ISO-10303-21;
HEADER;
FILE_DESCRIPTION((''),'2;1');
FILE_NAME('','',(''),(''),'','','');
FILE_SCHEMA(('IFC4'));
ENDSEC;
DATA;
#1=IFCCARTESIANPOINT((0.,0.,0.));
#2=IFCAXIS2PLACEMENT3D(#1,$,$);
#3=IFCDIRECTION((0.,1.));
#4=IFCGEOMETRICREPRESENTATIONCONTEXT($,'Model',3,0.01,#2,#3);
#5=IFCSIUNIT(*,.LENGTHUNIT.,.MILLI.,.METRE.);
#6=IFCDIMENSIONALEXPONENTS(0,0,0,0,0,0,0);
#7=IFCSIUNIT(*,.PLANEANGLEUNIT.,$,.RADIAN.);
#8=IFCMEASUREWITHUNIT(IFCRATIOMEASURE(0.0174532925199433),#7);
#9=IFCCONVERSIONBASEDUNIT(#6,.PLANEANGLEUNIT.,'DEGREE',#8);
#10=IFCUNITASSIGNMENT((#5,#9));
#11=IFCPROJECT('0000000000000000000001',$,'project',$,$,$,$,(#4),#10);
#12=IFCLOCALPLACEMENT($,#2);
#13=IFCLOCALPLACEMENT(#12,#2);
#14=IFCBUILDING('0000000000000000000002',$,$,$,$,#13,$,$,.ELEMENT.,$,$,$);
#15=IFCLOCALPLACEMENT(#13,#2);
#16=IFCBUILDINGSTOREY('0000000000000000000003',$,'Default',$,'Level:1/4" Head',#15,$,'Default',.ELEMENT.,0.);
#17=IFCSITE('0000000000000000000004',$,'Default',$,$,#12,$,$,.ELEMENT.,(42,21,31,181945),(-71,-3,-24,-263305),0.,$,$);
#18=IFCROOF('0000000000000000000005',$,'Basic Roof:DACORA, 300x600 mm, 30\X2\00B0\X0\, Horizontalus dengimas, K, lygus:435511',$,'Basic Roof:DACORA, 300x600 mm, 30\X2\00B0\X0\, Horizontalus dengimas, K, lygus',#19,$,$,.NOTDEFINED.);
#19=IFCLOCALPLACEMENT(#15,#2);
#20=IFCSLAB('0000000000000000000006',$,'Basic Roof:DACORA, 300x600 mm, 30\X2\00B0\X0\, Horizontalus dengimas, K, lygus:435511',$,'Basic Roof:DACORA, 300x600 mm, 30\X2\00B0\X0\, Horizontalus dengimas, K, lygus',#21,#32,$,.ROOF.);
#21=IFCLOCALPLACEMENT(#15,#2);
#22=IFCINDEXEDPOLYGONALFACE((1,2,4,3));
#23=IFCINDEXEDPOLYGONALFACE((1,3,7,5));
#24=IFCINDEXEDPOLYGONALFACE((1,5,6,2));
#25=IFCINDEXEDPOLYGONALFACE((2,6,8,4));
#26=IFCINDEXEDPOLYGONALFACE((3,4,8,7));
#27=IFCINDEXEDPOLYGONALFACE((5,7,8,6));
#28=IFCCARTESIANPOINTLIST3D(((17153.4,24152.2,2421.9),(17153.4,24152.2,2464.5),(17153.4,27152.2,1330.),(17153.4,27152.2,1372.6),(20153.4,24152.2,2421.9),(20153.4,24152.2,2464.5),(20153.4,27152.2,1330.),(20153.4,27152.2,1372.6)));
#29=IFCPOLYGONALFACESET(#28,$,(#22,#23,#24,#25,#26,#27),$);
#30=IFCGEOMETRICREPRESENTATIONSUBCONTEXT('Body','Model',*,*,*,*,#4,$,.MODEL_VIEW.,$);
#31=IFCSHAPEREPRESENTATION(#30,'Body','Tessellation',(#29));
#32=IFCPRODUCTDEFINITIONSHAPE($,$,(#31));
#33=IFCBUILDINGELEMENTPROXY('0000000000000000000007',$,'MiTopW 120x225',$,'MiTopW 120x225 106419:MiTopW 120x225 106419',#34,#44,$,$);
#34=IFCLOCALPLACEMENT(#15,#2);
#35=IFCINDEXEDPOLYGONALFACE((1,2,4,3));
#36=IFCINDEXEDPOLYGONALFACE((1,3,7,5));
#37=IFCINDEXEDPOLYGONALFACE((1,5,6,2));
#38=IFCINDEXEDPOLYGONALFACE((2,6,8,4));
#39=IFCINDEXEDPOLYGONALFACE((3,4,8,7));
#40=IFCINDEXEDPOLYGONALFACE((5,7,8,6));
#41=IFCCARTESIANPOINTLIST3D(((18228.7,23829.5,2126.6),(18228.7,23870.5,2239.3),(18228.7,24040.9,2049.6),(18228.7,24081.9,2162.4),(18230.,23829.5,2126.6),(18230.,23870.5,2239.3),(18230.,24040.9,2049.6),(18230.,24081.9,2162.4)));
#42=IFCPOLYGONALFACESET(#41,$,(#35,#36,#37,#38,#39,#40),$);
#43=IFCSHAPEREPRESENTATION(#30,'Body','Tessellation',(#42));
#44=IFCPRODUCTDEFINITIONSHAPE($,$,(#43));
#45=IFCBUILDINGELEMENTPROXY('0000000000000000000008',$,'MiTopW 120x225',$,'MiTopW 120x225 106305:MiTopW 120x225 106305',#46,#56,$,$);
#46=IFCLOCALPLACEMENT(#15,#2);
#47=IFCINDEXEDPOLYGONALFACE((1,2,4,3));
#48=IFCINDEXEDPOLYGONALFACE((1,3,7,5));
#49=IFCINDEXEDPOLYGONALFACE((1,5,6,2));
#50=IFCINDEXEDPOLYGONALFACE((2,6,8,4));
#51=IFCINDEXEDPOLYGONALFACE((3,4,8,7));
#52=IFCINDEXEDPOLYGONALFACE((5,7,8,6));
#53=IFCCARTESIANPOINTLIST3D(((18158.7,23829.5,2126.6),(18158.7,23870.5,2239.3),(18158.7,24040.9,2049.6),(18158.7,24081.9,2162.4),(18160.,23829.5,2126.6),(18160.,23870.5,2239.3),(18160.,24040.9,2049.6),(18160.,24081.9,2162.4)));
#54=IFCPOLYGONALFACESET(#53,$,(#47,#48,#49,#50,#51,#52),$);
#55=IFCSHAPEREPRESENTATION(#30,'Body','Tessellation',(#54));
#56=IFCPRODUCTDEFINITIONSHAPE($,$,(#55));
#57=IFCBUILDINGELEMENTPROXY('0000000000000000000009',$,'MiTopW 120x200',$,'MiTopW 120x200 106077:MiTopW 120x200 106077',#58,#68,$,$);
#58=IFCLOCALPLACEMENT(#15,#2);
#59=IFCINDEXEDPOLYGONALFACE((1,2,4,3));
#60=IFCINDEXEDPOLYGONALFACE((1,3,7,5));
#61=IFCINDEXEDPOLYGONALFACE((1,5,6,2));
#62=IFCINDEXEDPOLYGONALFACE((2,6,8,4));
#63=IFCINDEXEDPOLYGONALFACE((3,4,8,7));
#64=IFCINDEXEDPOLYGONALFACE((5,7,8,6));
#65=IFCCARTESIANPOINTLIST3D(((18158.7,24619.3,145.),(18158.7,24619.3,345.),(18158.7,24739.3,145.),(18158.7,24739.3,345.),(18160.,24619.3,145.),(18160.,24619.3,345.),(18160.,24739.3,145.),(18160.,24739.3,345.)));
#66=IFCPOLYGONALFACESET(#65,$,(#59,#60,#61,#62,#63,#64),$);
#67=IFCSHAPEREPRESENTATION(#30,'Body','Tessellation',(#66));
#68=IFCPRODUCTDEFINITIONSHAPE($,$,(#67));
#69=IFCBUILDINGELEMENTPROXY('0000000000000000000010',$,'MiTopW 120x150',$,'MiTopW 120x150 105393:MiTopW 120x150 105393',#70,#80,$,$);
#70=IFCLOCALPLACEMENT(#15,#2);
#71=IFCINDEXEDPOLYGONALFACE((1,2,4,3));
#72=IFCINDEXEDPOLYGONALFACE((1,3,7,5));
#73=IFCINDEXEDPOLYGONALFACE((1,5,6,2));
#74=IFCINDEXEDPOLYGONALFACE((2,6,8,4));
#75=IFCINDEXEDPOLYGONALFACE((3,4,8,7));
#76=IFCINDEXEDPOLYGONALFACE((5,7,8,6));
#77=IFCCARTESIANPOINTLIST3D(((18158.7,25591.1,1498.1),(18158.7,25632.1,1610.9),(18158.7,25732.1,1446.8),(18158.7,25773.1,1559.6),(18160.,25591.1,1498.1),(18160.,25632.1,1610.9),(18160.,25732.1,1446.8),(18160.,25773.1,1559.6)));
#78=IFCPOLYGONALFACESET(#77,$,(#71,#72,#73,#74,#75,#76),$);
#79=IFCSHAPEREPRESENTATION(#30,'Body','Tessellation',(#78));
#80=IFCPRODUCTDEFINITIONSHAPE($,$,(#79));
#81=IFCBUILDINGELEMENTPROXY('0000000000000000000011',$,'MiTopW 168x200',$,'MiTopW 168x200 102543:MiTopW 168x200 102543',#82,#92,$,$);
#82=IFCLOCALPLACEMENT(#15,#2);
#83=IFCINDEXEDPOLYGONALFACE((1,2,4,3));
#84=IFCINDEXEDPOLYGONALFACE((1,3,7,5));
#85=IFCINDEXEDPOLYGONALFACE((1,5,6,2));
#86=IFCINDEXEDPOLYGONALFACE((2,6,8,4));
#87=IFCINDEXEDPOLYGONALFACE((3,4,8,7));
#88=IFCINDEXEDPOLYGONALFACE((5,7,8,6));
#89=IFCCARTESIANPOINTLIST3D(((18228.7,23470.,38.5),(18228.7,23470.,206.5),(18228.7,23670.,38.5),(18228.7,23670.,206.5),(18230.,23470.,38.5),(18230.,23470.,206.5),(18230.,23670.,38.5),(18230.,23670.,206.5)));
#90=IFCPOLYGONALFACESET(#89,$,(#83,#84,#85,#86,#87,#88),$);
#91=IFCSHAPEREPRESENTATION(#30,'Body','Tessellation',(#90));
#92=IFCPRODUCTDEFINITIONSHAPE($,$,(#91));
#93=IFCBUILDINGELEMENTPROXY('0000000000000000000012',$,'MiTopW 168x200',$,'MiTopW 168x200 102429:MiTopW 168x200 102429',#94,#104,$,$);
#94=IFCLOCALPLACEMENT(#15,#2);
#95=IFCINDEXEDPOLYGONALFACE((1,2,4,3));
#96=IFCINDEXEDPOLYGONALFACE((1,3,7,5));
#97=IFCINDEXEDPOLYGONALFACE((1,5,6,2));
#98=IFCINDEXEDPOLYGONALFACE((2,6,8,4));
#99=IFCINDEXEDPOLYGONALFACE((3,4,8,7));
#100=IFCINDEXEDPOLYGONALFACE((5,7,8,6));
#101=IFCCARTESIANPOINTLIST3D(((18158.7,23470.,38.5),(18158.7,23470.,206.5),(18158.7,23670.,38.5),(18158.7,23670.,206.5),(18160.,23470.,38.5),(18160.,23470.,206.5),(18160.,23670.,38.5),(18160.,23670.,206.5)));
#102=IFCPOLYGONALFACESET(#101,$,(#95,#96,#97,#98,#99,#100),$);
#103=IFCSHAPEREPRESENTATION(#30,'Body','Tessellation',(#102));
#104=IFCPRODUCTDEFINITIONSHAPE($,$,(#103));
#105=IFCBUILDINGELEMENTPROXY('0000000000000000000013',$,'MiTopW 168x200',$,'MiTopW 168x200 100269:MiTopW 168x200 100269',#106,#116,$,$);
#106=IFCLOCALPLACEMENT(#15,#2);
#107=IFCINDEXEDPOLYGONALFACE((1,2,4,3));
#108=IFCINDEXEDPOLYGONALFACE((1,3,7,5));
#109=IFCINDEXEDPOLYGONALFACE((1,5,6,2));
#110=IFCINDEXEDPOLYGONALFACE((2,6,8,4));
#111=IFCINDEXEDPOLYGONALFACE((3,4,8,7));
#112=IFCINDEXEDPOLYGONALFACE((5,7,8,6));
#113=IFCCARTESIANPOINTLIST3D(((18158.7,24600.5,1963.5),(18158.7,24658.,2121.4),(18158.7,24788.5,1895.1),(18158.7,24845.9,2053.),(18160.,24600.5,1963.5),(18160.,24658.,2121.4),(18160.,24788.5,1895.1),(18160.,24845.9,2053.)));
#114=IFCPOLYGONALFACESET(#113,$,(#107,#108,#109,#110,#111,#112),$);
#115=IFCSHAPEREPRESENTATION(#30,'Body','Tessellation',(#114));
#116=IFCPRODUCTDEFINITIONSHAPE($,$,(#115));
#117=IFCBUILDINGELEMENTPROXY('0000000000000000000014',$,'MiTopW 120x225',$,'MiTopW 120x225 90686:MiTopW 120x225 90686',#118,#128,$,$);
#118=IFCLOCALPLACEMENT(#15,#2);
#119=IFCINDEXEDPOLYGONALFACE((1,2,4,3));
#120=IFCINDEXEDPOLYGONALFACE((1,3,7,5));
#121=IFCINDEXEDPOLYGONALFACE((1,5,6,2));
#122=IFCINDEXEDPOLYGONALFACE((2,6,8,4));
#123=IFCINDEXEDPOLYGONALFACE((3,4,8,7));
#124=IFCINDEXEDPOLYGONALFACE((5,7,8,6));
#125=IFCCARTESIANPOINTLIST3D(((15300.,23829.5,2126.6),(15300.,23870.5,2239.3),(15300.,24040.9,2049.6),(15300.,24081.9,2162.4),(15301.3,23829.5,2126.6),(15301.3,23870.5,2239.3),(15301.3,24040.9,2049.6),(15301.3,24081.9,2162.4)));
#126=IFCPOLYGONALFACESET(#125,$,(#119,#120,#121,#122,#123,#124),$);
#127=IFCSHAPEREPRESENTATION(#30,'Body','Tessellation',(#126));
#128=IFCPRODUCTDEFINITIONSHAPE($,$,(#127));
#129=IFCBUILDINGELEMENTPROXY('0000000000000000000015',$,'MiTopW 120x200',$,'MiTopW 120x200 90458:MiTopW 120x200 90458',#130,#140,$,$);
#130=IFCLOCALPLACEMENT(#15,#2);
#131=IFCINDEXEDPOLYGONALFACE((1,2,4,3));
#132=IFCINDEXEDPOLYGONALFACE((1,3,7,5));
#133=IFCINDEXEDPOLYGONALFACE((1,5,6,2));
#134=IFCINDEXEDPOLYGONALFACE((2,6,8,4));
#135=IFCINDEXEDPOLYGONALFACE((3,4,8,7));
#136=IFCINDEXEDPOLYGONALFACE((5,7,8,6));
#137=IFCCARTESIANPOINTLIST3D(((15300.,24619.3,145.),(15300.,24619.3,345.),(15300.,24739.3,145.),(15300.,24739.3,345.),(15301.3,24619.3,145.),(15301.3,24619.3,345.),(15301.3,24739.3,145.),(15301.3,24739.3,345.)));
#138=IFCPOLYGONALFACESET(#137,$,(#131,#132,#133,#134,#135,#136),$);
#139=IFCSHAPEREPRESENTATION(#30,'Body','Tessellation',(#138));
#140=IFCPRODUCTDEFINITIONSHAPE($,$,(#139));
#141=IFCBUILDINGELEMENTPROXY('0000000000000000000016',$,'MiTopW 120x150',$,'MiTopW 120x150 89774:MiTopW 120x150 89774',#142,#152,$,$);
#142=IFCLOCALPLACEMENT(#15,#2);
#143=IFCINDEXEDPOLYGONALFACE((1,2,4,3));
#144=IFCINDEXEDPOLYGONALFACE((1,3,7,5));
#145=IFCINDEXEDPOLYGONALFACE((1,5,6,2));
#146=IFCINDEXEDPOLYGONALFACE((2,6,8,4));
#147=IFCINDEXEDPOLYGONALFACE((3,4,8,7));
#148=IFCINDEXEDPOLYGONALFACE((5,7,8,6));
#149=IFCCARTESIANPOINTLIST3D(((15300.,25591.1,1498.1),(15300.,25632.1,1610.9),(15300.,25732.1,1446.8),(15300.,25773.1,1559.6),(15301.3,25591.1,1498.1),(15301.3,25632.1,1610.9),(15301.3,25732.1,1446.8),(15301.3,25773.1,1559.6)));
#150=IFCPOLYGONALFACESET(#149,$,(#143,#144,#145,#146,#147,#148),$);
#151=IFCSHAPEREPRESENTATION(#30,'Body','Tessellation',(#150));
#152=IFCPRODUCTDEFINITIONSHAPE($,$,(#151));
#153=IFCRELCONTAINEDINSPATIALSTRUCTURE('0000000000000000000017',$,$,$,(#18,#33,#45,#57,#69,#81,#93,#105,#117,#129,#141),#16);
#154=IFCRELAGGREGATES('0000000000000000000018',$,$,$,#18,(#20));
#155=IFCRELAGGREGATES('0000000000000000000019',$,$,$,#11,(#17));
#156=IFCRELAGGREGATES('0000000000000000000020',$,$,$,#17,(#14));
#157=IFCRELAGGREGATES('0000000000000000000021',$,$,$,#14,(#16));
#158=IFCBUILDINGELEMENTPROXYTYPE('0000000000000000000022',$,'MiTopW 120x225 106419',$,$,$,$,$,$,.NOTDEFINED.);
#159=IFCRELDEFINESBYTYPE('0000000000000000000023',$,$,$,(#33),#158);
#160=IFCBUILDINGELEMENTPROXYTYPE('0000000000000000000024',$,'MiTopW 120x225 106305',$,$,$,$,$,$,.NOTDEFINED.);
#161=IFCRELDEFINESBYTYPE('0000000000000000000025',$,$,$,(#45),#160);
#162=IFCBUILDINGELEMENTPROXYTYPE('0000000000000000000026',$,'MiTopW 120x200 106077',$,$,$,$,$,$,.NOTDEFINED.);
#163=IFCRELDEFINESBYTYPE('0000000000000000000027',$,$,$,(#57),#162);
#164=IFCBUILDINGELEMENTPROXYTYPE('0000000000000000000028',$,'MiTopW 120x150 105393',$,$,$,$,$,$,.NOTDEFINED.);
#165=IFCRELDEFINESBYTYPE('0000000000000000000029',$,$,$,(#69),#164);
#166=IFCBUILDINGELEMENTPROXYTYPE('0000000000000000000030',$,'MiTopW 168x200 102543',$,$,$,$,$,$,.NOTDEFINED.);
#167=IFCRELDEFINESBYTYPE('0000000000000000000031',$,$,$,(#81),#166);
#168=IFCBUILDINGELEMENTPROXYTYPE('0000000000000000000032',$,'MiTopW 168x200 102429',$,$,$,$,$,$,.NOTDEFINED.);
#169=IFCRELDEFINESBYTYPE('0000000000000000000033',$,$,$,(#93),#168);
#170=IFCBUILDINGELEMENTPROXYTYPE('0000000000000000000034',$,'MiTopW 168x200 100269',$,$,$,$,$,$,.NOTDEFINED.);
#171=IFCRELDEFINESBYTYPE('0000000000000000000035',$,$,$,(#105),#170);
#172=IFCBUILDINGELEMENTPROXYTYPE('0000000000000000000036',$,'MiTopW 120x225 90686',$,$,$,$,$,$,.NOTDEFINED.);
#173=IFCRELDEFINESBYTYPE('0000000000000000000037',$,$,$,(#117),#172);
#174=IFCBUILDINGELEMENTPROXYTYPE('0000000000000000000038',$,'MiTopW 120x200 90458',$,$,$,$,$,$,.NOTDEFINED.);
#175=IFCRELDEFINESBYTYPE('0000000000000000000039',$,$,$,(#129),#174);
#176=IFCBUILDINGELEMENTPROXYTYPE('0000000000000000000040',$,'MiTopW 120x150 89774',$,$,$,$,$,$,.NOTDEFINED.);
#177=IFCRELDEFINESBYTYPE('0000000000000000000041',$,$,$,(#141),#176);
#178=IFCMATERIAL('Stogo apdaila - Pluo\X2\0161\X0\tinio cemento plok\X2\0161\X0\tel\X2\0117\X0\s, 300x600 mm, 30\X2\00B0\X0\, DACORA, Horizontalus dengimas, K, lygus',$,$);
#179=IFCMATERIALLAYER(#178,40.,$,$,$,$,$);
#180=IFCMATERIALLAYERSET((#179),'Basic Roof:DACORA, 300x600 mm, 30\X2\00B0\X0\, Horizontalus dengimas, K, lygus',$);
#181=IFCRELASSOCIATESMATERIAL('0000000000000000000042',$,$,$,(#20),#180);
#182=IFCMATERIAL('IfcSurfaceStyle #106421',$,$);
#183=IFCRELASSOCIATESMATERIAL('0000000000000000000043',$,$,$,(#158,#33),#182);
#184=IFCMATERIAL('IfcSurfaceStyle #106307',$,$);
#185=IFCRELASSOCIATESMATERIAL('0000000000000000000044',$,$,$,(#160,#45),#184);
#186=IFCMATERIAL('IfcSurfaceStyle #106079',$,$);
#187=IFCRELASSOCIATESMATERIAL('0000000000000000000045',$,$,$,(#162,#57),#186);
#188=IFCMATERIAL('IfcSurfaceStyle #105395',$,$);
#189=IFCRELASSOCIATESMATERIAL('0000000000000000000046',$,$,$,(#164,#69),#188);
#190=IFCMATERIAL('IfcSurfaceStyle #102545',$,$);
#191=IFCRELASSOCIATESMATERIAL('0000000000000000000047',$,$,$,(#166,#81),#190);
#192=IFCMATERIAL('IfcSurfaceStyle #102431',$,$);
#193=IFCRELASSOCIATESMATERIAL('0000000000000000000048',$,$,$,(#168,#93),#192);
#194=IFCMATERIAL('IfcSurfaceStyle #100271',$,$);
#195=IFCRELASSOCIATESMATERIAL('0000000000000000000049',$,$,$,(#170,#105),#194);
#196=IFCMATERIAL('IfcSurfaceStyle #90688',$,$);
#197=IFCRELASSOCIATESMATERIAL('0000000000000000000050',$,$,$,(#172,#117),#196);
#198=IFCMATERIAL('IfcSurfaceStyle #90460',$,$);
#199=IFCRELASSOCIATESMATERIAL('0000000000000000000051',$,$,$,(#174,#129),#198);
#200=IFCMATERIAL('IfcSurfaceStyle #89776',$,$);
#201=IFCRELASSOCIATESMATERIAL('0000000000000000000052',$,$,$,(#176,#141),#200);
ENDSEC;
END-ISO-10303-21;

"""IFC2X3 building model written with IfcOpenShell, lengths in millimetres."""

from ifc_helpers import new_model, entity, si_unit, converted_unit, direction, frame, frame_2d, origin, origin_2d_with_axis, place, context, subcontext, project, spatial, polyline, rectangle, outline, extrude, source, transform, mapped, material, layer, layer_set, type_object, type_shapes, element, aggregate, save


model = new_model("IFC2X3")

# Units and contexts
model_context = context("Model", 3, precision=0.01, world=origin(), true_north=direction((0.0, 1.0)))
body_context = subcontext(model_context, "Body", "Model", "MODEL_VIEW")
ifc_project = project(units=[si_unit("LENGTHUNIT", "METRE", prefix="MILLI"), converted_unit("PLANEANGLEUNIT", "DEGREE", entity("IfcRatioMeasure", 0.0174532925199433), si_unit("PLANEANGLEUNIT", "RADIAN"), dimensions=[0, 0, 0, 0, 0, 0, 0])], contexts=[model_context])

# Site, building, storey
site_placement = place(None, origin())
site = spatial("IfcSite", under=ifc_project, at=site_placement, Name="Default", CompositionType="ELEMENT", RefLatitude=(42, 21, 31, 181945), RefLongitude=(-71, -3, -24, -263305), RefElevation=0.0)
building_placement = place(site_placement, origin())
building = spatial("IfcBuilding", under=site, at=building_placement, CompositionType="ELEMENT")
storey_placement = place(building_placement, origin())
storey = spatial("IfcBuildingStorey", under=building, at=storey_placement, Name="Default", ObjectType="Level:1/4\" Head", LongName="Default", CompositionType="ELEMENT", Elevation=0.0)

# Roof, slab
roof_placement = place(storey_placement, frame((17153.4, 24152.2, 1330.0)))
roof = element("IfcRoof", 1, at=roof_placement, inside=storey, Name="Basic Roof:DACORA, 300x600 mm, 30°, Horizontalus dengimas, K, lygus:435511", ObjectType="Basic Roof:DACORA, 300x600 mm, 30°, Horizontalus dengimas, K, lygus", ShapeType="NOTDEFINED")
ifc_material_1 = material(Name="Stogo apdaila - Pluoštinio cemento plokštelės, 300x600 mm, 30°, DACORA, Horizontalus dengimas, K, lygus")
ifc_layer = layer(ifc_material_1, 40.0)
ifc_layer_set = layer_set([ifc_layer], Name="Basic Roof:DACORA, 300x600 mm, 30°, Horizontalus dengimas, K, lygus")
slab_placement = place(roof_placement, origin())
slab = element("IfcSlab", 2, at=slab_placement, material=ifc_layer_set, Name="Basic Roof:DACORA, 300x600 mm, 30°, Horizontalus dengimas, K, lygus:435511", ObjectType="Basic Roof:DACORA, 300x600 mm, 30°, Horizontalus dengimas, K, lygus", PredefinedType="ROOF", context=body_context, shape_type="SweptSolid", body=[
    extrude(rectangle(XDim=3192.5, YDim=3000.0, at=frame_2d((0.0, 0.0), x_axis=(0.0, 1.0))), frame((1500.0, 1500.0, 546.0), z_axis=(0.0, 0.34202, 0.939693), x_axis=(1.0, 0.0, 0.0)), (0.0, -0.34202, 0.939693), 42.6),
])
aggregate(roof, [slab])

# Building element proxies
ifc_material_2 = material(Name="IfcSurfaceStyle #106421")
building_element_proxy_type_1 = type_object("IfcBuildingElementProxyType", Name="MiTopW 120x225 106419", PredefinedType="NOTDEFINED", material=ifc_material_2)
shared_shape_1 = source(origin(), body_context, "Body", "SweptSolid", [
    extrude(outline(polyline([(-112.5, -60.0), (112.5, -60.0), (112.5, 60.0), (-112.5, 60.0), (-112.5, -60.0)])), frame((112.5, 60.0, 0.0), z_axis=(0.0, 0.0, 1.0), x_axis=(-1.0, 0.0, 0.0)), (0.0, 0.0, 1.0), 1.3),
])
type_shapes(building_element_proxy_type_1, [shared_shape_1])
proxy_1_placement = place(building_placement, frame((18230.0, 24040.9, 2049.6), z_axis=(-1.0, 0.0, 0.0), x_axis=(0.0, -0.939693, 0.34202)))
element("IfcBuildingElementProxy", 3, at=proxy_1_placement, inside=storey, type_object=building_element_proxy_type_1, material=ifc_material_2, Name="MiTopW 120x225", ObjectType="MiTopW 120x225 106419:MiTopW 120x225 106419", context=body_context, shape_type="MappedRepresentation", body=[
    mapped(shared_shape_1, transform((0.0, 0.0, 0.0), scale=1.0)),
])
ifc_material_3 = material(Name="IfcSurfaceStyle #106307")
building_element_proxy_type_2 = type_object("IfcBuildingElementProxyType", Name="MiTopW 120x225 106305", PredefinedType="NOTDEFINED", material=ifc_material_3)
shared_shape_2 = source(origin(), body_context, "Body", "SweptSolid", [
    extrude(outline(polyline([(-112.5, -60.0), (112.5, -60.0), (112.5, 60.0), (-112.5, 60.0), (-112.5, -60.0)])), frame((112.5, 60.0, 0.0), z_axis=(0.0, 0.0, 1.0), x_axis=(-1.0, 0.0, 0.0)), (0.0, 0.0, 1.0), 1.3),
])
type_shapes(building_element_proxy_type_2, [shared_shape_2])
proxy_2_placement = place(building_placement, frame((18160.0, 24040.9, 2049.6), z_axis=(-1.0, 0.0, 0.0), x_axis=(0.0, -0.939693, 0.34202)))
element("IfcBuildingElementProxy", 4, at=proxy_2_placement, inside=storey, type_object=building_element_proxy_type_2, material=ifc_material_3, Name="MiTopW 120x225", ObjectType="MiTopW 120x225 106305:MiTopW 120x225 106305", context=body_context, shape_type="MappedRepresentation", body=[
    mapped(shared_shape_2, transform((0.0, 0.0, 0.0), scale=1.0)),
])
ifc_material_4 = material(Name="IfcSurfaceStyle #106079")
building_element_proxy_type_3 = type_object("IfcBuildingElementProxyType", Name="MiTopW 120x200 106077", PredefinedType="NOTDEFINED", material=ifc_material_4)
shared_shape_3 = source(origin(), body_context, "Body", "SweptSolid", [
    extrude(rectangle(XDim=200.0, YDim=120.0, at=origin_2d_with_axis()), frame((100.0, 60.0, 0.0), z_axis=(0.0, 0.0, 1.0), x_axis=(-1.0, 0.0, 0.0)), (0.0, 0.0, 1.0), 1.3),
])
type_shapes(building_element_proxy_type_3, [shared_shape_3])
proxy_3_placement = place(building_placement, frame((18160.0, 24619.3, 145.0), z_axis=(-1.0, 0.0, 0.0), x_axis=(0.0, 0.0, 1.0)))
element("IfcBuildingElementProxy", 5, at=proxy_3_placement, inside=storey, type_object=building_element_proxy_type_3, material=ifc_material_4, Name="MiTopW 120x200", ObjectType="MiTopW 120x200 106077:MiTopW 120x200 106077", context=body_context, shape_type="MappedRepresentation", body=[
    mapped(shared_shape_3, transform((0.0, 0.0, 0.0), scale=1.0)),
])
ifc_material_5 = material(Name="IfcSurfaceStyle #105395")
building_element_proxy_type_4 = type_object("IfcBuildingElementProxyType", Name="MiTopW 120x150 105393", PredefinedType="NOTDEFINED", material=ifc_material_5)
shared_shape_4 = source(origin(), body_context, "Body", "SweptSolid", [
    extrude(outline(polyline([(-75.0, -60.0), (75.0, -60.0), (75.0, 60.0), (-75.0, 60.0), (-75.0, -60.0)])), frame((75.0, 60.0, 0.0), z_axis=(0.0, 0.0, 1.0), x_axis=(-1.0, 0.0, 0.0)), (0.0, 0.0, 1.0), 1.3),
])
type_shapes(building_element_proxy_type_4, [shared_shape_4])
proxy_4_placement = place(building_placement, frame((18160.0, 25732.1, 1446.8), z_axis=(-1.0, 0.0, 0.0), x_axis=(0.0, -0.939693, 0.34202)))
element("IfcBuildingElementProxy", 6, at=proxy_4_placement, inside=storey, type_object=building_element_proxy_type_4, material=ifc_material_5, Name="MiTopW 120x150", ObjectType="MiTopW 120x150 105393:MiTopW 120x150 105393", context=body_context, shape_type="MappedRepresentation", body=[
    mapped(shared_shape_4, transform((0.0, 0.0, 0.0), scale=1.0)),
])
ifc_material_6 = material(Name="IfcSurfaceStyle #102545")
building_element_proxy_type_5 = type_object("IfcBuildingElementProxyType", Name="MiTopW 168x200 102543", PredefinedType="NOTDEFINED", material=ifc_material_6)
shared_shape_5 = source(origin(), body_context, "Body", "SweptSolid", [
    extrude(rectangle(XDim=200.0, YDim=168.0, at=origin_2d_with_axis()), frame((100.0, 84.0, 0.0), z_axis=(0.0, 0.0, 1.0), x_axis=(-1.0, 0.0, 0.0)), (0.0, 0.0, 1.0), 1.3),
])
type_shapes(building_element_proxy_type_5, [shared_shape_5])
proxy_5_placement = place(building_placement, frame((18230.0, 23470.0, 206.5), z_axis=(-1.0, 0.0, 0.0), x_axis=(0.0, 1.0, 0.0)))
element("IfcBuildingElementProxy", 7, at=proxy_5_placement, inside=storey, type_object=building_element_proxy_type_5, material=ifc_material_6, Name="MiTopW 168x200", ObjectType="MiTopW 168x200 102543:MiTopW 168x200 102543", context=body_context, shape_type="MappedRepresentation", body=[
    mapped(shared_shape_5, transform((0.0, 0.0, 0.0), scale=1.0)),
])
ifc_material_7 = material(Name="IfcSurfaceStyle #102431")
building_element_proxy_type_6 = type_object("IfcBuildingElementProxyType", Name="MiTopW 168x200 102429", PredefinedType="NOTDEFINED", material=ifc_material_7)
shared_shape_6 = source(origin(), body_context, "Body", "SweptSolid", [
    extrude(rectangle(XDim=200.0, YDim=168.0, at=origin_2d_with_axis()), frame((100.0, 84.0, 0.0), z_axis=(0.0, 0.0, 1.0), x_axis=(-1.0, 0.0, 0.0)), (0.0, 0.0, 1.0), 1.3),
])
type_shapes(building_element_proxy_type_6, [shared_shape_6])
proxy_6_placement = place(building_placement, frame((18160.0, 23470.0, 206.5), z_axis=(-1.0, 0.0, 0.0), x_axis=(0.0, 1.0, 0.0)))
element("IfcBuildingElementProxy", 8, at=proxy_6_placement, inside=storey, type_object=building_element_proxy_type_6, material=ifc_material_7, Name="MiTopW 168x200", ObjectType="MiTopW 168x200 102429:MiTopW 168x200 102429", context=body_context, shape_type="MappedRepresentation", body=[
    mapped(shared_shape_6, transform((0.0, 0.0, 0.0), scale=1.0)),
])
ifc_material_8 = material(Name="IfcSurfaceStyle #100271")
building_element_proxy_type_7 = type_object("IfcBuildingElementProxyType", Name="MiTopW 168x200 100269", PredefinedType="NOTDEFINED", material=ifc_material_8)
shared_shape_7 = source(origin(), body_context, "Body", "SweptSolid", [
    extrude(outline(polyline([(-100.0, -84.0), (100.0, -84.0), (100.0, 84.0), (-100.0, 84.0), (-100.0, -84.0)])), frame((100.0, 84.0, 0.0), z_axis=(0.0, 0.0, 1.0), x_axis=(-1.0, 0.0, 0.0)), (0.0, 0.0, 1.0), 1.3),
])
type_shapes(building_element_proxy_type_7, [shared_shape_7])
proxy_7_placement = place(building_placement, frame((18160.0, 24788.5, 1895.1), z_axis=(-1.0, 0.0, 0.0), x_axis=(0.0, -0.939693, 0.34202)))
element("IfcBuildingElementProxy", 9, at=proxy_7_placement, inside=storey, type_object=building_element_proxy_type_7, material=ifc_material_8, Name="MiTopW 168x200", ObjectType="MiTopW 168x200 100269:MiTopW 168x200 100269", context=body_context, shape_type="MappedRepresentation", body=[
    mapped(shared_shape_7, transform((0.0, 0.0, 0.0), scale=1.0)),
])
ifc_material_9 = material(Name="IfcSurfaceStyle #90688")
building_element_proxy_type_8 = type_object("IfcBuildingElementProxyType", Name="MiTopW 120x225 90686", PredefinedType="NOTDEFINED", material=ifc_material_9)
shared_shape_8 = source(origin(), body_context, "Body", "SweptSolid", [
    extrude(outline(polyline([(-112.5, -60.0), (112.5, -60.0), (112.5, 60.0), (-112.5, 60.0), (-112.5, -60.0)])), frame((112.5, 60.0, 0.0), z_axis=(0.0, 0.0, 1.0), x_axis=(-1.0, 0.0, 0.0)), (0.0, 0.0, 1.0), 1.3),
])
type_shapes(building_element_proxy_type_8, [shared_shape_8])
proxy_8_placement = place(building_placement, frame((15301.3, 24040.9, 2049.6), z_axis=(-1.0, 0.0, 0.0), x_axis=(0.0, -0.939693, 0.34202)))
element("IfcBuildingElementProxy", 10, at=proxy_8_placement, inside=storey, type_object=building_element_proxy_type_8, material=ifc_material_9, Name="MiTopW 120x225", ObjectType="MiTopW 120x225 90686:MiTopW 120x225 90686", context=body_context, shape_type="MappedRepresentation", body=[
    mapped(shared_shape_8, transform((0.0, 0.0, 0.0), scale=1.0)),
])
ifc_material_10 = material(Name="IfcSurfaceStyle #90460")
building_element_proxy_type_9 = type_object("IfcBuildingElementProxyType", Name="MiTopW 120x200 90458", PredefinedType="NOTDEFINED", material=ifc_material_10)
shared_shape_9 = source(origin(), body_context, "Body", "SweptSolid", [
    extrude(rectangle(XDim=200.0, YDim=120.0, at=origin_2d_with_axis()), frame((100.0, 60.0, 0.0), z_axis=(0.0, 0.0, 1.0), x_axis=(-1.0, 0.0, 0.0)), (0.0, 0.0, 1.0), 1.3),
])
type_shapes(building_element_proxy_type_9, [shared_shape_9])
proxy_9_placement = place(building_placement, frame((15301.3, 24619.3, 145.0), z_axis=(-1.0, 0.0, 0.0), x_axis=(0.0, 0.0, 1.0)))
element("IfcBuildingElementProxy", 11, at=proxy_9_placement, inside=storey, type_object=building_element_proxy_type_9, material=ifc_material_10, Name="MiTopW 120x200", ObjectType="MiTopW 120x200 90458:MiTopW 120x200 90458", context=body_context, shape_type="MappedRepresentation", body=[
    mapped(shared_shape_9, transform((0.0, 0.0, 0.0), scale=1.0)),
])
ifc_material_11 = material(Name="IfcSurfaceStyle #89776")
building_element_proxy_type_10 = type_object("IfcBuildingElementProxyType", Name="MiTopW 120x150 89774", PredefinedType="NOTDEFINED", material=ifc_material_11)
shared_shape_10 = source(origin(), body_context, "Body", "SweptSolid", [
    extrude(outline(polyline([(-75.0, -60.0), (75.0, -60.0), (75.0, 60.0), (-75.0, 60.0), (-75.0, -60.0)])), frame((75.0, 60.0, 0.0), z_axis=(0.0, 0.0, 1.0), x_axis=(-1.0, 0.0, 0.0)), (0.0, 0.0, 1.0), 1.3),
])
type_shapes(building_element_proxy_type_10, [shared_shape_10])
proxy_10_placement = place(building_placement, frame((15301.3, 25732.1, 1446.8), z_axis=(-1.0, 0.0, 0.0), x_axis=(0.0, -0.939693, 0.34202)))
element("IfcBuildingElementProxy", 12, at=proxy_10_placement, inside=storey, type_object=building_element_proxy_type_10, material=ifc_material_11, Name="MiTopW 120x150", ObjectType="MiTopW 120x150 89774:MiTopW 120x150 89774", context=body_context, shape_type="MappedRepresentation", body=[
    mapped(shared_shape_10, transform((0.0, 0.0, 0.0), scale=1.0)),
])

save(model, "model.ifc")
